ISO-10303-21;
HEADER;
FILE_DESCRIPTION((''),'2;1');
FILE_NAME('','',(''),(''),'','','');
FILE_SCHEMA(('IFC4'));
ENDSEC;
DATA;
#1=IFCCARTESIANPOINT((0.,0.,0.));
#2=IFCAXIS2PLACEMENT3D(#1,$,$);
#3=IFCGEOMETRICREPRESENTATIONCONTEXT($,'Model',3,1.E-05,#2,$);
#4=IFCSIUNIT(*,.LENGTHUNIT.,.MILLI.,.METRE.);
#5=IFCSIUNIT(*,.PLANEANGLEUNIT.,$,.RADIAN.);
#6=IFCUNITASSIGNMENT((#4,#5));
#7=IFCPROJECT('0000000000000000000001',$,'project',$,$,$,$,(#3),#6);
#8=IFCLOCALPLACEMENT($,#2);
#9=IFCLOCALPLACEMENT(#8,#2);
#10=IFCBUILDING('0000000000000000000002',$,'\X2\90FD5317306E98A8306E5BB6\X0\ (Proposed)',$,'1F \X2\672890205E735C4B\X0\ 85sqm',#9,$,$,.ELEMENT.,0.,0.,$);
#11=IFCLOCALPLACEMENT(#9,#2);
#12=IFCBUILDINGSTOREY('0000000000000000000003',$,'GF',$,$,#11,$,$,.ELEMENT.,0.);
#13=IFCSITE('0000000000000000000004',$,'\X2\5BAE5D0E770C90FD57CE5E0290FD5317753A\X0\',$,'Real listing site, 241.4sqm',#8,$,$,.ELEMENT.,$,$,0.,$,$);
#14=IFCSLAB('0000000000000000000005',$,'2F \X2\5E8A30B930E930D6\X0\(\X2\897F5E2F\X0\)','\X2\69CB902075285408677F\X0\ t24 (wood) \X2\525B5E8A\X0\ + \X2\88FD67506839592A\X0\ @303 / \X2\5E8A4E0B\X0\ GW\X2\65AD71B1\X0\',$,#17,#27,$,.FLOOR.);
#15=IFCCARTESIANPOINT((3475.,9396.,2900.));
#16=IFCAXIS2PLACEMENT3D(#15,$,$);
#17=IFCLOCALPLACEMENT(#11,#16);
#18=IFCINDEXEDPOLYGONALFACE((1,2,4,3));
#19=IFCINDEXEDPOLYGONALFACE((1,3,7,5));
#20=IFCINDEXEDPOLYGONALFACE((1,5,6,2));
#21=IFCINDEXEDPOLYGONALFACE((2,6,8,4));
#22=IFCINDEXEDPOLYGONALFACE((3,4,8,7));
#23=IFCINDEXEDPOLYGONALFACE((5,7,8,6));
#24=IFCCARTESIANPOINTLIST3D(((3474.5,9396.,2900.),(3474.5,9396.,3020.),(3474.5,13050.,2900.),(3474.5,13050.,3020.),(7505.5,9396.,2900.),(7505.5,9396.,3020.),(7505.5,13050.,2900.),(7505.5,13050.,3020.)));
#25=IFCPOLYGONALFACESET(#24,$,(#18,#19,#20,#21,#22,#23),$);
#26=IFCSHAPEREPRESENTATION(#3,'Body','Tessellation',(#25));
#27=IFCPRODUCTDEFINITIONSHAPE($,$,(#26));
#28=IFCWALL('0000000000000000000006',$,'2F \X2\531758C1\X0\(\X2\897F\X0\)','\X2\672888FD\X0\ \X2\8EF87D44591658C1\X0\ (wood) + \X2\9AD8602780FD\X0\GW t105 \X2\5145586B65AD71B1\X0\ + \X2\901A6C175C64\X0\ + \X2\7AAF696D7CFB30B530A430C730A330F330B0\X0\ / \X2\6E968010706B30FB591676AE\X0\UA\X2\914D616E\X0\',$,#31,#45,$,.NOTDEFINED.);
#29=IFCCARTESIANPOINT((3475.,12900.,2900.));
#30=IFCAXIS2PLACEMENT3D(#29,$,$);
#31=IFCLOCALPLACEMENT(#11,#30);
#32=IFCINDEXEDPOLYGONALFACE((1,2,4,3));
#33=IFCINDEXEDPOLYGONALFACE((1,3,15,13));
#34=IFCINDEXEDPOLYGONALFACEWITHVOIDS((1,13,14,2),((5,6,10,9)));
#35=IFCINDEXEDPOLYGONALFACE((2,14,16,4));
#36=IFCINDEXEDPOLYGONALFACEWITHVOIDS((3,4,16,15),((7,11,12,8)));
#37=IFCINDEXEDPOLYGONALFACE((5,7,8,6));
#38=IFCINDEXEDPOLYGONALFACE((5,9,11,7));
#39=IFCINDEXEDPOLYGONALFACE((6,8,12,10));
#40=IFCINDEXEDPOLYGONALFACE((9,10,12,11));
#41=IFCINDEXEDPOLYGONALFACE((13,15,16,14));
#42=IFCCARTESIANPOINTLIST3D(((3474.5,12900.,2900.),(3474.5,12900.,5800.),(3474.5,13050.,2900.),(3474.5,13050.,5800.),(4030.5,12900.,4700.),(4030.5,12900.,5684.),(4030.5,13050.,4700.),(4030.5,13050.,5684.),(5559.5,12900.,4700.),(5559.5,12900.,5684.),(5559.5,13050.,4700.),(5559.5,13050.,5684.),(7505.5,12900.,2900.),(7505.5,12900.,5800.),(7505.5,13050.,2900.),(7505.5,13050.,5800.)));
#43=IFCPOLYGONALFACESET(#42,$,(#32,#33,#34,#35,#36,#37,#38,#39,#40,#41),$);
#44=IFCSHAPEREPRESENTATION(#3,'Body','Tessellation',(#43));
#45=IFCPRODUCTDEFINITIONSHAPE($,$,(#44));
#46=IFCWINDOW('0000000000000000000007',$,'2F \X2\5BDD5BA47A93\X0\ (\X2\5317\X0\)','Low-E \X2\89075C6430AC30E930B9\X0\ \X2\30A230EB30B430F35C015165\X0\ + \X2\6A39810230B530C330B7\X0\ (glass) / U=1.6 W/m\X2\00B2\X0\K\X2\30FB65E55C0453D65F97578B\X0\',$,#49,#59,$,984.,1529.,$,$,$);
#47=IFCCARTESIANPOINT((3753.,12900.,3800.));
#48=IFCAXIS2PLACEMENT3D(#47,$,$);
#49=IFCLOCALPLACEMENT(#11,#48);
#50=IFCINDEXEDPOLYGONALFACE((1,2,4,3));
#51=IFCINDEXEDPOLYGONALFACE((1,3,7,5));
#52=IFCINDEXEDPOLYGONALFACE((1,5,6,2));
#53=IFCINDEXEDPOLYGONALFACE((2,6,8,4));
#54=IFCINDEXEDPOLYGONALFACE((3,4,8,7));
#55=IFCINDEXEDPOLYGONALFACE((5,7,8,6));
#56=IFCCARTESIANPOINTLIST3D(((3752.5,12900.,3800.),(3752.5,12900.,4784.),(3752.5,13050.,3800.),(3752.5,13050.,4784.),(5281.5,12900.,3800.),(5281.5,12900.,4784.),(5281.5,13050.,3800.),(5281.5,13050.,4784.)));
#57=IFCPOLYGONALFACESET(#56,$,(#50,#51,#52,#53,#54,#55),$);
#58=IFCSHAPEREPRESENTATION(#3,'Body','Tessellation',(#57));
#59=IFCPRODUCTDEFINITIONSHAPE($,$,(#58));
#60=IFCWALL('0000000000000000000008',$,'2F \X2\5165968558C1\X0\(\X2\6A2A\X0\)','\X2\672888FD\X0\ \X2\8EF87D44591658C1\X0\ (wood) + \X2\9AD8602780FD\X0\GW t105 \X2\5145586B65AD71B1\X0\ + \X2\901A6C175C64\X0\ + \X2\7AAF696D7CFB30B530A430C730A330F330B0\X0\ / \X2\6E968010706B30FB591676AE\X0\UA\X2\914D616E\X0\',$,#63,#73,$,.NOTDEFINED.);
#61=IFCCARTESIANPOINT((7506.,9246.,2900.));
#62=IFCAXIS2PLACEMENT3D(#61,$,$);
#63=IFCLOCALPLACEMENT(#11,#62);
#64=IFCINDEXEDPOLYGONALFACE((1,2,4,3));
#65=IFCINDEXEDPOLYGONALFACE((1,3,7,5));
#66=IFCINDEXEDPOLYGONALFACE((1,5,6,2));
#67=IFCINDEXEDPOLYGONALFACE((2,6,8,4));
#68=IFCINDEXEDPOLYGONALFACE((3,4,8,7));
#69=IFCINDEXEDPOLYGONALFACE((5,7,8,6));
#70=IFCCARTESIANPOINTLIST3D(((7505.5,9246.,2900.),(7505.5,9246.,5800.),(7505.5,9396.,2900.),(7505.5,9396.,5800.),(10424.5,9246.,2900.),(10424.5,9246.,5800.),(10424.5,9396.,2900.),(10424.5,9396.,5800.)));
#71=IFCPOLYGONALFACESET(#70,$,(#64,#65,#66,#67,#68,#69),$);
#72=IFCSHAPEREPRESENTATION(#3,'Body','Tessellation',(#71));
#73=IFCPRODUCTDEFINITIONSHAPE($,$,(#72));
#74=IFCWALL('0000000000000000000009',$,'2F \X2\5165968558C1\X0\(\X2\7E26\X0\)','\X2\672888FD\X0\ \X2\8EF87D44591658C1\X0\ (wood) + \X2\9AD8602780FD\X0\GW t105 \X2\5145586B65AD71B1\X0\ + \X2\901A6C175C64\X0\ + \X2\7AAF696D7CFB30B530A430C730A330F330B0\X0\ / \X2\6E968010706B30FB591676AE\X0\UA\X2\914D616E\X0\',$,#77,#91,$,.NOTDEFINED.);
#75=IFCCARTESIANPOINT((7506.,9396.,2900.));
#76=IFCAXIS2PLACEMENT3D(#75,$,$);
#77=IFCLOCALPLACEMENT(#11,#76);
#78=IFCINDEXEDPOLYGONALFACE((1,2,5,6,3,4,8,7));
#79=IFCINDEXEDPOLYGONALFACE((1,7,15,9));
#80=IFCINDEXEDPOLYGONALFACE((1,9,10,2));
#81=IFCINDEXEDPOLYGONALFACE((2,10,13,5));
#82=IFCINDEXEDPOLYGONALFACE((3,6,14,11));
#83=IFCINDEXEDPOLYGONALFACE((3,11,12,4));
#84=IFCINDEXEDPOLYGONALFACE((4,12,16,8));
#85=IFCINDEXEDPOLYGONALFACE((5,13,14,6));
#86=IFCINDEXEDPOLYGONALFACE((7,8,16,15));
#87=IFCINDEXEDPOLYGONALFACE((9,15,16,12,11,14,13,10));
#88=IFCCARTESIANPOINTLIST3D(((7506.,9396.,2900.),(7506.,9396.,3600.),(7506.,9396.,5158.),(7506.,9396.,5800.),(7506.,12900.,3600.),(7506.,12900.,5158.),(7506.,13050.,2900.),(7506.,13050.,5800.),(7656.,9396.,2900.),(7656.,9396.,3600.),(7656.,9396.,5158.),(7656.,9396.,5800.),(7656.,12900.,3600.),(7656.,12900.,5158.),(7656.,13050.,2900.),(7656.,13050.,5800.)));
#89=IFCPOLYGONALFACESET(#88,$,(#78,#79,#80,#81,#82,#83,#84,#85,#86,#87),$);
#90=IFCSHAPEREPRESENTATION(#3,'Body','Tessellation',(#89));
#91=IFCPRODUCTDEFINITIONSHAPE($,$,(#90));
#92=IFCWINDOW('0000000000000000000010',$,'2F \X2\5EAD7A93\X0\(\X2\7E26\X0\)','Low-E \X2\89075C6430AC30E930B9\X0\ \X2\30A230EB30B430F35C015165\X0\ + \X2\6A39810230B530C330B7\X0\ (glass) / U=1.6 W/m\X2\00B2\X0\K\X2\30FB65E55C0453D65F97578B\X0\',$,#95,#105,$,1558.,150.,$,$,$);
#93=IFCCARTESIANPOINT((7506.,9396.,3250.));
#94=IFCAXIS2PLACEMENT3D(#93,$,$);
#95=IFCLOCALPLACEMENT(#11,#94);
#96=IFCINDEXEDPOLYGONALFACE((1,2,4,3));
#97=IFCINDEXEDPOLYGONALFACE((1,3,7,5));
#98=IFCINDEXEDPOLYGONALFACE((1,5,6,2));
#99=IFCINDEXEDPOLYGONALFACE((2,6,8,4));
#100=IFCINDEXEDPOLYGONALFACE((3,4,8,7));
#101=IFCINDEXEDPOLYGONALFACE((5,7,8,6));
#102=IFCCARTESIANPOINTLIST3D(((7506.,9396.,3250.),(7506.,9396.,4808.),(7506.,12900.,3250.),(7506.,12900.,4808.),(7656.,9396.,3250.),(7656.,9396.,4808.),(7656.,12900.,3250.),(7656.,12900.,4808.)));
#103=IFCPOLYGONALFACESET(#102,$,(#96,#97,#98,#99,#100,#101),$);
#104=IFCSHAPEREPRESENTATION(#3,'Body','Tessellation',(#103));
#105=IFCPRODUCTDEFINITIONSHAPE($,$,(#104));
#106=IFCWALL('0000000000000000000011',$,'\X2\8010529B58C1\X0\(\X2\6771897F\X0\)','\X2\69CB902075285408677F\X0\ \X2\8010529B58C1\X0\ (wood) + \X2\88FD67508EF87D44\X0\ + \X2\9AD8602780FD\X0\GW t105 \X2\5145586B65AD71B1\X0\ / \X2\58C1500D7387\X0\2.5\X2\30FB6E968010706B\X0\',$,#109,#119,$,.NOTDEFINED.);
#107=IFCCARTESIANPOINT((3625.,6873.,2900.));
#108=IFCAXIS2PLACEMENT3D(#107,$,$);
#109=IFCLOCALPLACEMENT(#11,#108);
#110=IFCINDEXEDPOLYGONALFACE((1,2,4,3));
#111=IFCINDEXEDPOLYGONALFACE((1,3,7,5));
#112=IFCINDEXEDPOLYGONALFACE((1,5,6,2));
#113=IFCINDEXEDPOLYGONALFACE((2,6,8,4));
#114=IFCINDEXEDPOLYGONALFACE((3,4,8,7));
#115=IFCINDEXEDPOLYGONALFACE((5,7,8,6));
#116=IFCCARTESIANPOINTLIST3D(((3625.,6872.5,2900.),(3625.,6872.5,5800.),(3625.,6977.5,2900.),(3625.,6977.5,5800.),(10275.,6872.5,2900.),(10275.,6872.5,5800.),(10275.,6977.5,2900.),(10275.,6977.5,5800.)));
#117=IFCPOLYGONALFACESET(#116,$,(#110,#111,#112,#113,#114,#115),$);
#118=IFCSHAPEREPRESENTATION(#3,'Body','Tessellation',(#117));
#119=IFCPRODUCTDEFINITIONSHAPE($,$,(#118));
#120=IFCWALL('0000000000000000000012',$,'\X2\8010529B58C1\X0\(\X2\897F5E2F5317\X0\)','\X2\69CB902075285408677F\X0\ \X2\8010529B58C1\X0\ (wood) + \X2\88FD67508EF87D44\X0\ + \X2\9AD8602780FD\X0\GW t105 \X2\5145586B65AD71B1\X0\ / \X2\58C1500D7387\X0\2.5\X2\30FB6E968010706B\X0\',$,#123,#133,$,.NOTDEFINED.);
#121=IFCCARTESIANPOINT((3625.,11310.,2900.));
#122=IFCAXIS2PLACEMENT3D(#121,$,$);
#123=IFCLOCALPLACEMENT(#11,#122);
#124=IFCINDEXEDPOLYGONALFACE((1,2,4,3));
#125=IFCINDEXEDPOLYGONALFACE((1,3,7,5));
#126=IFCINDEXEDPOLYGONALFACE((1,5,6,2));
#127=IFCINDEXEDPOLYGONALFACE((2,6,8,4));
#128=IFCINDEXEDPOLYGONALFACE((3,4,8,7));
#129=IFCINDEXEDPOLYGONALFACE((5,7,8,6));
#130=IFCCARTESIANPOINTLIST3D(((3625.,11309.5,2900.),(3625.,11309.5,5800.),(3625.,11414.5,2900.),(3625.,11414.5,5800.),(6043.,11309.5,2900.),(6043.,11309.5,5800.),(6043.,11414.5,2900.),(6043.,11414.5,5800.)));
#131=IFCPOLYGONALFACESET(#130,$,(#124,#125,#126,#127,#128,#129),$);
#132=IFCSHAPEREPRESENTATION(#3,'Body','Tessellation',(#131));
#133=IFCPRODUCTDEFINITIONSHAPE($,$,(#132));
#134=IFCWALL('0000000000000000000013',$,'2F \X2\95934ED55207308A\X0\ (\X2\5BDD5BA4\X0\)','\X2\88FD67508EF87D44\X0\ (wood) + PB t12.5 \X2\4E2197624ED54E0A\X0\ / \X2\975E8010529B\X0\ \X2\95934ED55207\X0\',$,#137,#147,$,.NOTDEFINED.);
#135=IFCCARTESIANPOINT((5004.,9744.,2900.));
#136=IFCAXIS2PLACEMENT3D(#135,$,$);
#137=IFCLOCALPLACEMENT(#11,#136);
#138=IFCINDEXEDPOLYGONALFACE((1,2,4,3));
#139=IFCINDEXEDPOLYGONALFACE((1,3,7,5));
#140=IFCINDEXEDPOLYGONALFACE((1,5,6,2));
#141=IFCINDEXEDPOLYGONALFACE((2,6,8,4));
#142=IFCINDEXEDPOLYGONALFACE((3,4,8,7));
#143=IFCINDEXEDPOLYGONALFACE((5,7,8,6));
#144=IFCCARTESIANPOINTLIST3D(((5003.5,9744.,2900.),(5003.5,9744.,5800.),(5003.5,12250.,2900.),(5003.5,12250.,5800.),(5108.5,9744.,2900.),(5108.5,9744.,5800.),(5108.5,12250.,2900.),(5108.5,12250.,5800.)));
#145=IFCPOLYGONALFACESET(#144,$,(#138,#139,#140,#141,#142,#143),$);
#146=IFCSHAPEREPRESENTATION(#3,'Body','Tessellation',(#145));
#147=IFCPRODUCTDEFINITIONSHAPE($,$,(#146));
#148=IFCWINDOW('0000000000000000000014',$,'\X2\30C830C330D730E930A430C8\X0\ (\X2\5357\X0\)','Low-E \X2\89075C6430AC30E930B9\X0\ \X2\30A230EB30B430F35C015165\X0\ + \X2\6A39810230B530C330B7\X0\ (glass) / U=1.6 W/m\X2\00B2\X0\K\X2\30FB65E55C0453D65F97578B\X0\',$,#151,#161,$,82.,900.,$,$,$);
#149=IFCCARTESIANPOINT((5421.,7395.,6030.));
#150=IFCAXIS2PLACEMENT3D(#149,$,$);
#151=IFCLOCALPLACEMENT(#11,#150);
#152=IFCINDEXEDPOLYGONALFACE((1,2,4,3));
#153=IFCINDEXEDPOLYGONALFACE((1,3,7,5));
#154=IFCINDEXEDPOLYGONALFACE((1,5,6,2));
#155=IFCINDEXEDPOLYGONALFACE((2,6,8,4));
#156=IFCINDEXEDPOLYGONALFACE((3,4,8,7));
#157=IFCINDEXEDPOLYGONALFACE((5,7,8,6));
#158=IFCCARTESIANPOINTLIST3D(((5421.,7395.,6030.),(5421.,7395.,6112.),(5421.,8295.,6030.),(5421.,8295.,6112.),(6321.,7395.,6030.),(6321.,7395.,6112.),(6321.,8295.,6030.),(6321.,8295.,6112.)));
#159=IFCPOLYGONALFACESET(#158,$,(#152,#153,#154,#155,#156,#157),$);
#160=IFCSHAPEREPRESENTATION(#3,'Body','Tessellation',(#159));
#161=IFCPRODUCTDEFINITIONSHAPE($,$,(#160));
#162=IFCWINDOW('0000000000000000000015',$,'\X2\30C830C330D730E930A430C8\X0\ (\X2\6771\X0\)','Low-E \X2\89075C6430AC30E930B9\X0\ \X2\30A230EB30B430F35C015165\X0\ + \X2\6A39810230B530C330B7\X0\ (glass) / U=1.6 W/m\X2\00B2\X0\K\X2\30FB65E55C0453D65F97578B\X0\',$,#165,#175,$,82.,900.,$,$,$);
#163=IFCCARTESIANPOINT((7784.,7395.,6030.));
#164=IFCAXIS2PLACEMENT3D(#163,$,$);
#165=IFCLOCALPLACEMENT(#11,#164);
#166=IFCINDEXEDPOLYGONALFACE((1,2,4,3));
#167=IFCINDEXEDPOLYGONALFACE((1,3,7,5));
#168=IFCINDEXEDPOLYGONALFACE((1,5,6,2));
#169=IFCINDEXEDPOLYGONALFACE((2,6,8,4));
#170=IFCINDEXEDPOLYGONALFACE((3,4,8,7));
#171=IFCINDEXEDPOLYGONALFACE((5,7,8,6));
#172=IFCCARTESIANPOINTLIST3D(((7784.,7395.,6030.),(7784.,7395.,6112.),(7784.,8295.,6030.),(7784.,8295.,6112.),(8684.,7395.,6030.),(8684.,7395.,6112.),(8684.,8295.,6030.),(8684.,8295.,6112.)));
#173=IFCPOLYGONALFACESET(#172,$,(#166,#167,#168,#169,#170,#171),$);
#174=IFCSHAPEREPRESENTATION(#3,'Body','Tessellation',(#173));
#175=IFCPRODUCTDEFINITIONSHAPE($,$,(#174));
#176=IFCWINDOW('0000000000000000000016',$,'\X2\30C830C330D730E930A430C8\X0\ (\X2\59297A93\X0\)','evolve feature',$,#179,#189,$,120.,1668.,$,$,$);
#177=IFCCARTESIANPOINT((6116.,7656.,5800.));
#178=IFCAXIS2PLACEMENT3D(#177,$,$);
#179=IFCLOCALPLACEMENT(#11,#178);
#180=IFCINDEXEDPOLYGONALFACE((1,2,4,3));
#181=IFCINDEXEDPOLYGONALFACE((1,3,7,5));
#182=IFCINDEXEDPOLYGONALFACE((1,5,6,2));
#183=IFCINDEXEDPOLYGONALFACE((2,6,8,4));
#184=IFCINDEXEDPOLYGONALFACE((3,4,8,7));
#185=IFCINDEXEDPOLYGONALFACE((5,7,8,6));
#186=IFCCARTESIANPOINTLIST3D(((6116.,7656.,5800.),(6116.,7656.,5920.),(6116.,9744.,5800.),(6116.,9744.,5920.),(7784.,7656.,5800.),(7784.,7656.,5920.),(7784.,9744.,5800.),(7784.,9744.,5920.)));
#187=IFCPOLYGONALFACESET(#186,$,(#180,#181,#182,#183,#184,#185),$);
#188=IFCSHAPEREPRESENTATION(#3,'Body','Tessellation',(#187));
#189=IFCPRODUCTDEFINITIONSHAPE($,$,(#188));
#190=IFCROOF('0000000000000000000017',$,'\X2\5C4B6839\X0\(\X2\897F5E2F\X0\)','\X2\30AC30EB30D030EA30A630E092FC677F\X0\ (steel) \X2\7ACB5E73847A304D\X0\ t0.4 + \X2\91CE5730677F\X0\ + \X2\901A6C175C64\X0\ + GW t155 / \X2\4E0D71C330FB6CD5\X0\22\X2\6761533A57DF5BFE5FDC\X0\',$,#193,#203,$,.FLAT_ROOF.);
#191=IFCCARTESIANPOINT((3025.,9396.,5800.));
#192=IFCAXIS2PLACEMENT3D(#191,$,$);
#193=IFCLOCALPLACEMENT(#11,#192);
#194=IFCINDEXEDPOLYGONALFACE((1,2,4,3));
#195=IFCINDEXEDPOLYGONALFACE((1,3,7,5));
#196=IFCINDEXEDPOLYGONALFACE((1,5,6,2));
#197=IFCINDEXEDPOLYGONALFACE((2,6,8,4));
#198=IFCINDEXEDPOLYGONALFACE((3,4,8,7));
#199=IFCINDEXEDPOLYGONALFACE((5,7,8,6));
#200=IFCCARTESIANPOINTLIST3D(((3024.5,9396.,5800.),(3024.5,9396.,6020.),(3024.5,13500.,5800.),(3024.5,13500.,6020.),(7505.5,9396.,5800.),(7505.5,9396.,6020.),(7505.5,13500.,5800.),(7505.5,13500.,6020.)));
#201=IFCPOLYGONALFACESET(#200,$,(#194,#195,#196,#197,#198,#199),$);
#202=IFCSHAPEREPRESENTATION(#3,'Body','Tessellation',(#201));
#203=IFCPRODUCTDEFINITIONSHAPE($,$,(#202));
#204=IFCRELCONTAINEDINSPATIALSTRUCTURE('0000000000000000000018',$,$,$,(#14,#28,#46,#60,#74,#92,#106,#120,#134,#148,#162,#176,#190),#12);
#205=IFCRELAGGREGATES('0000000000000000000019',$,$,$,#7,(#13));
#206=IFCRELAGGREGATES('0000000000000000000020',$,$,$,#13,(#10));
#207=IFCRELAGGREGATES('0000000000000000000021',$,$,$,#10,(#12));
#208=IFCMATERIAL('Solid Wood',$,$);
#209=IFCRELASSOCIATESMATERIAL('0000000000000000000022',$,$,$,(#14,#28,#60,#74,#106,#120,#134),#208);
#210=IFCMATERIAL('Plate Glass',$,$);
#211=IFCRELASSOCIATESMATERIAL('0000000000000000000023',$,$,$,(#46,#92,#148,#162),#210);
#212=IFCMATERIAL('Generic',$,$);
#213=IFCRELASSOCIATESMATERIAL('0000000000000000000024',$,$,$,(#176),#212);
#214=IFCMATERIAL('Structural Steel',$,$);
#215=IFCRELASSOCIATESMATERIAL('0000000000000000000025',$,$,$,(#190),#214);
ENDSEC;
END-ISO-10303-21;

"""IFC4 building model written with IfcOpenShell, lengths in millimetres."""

from ifc_helpers import new_model, si_unit, frame, frame_2d, origin, place, context, project, spatial, rectangle, extrude, material, element, fill, save


model = new_model("IFC4")

# Units and contexts
model_context = context("Model", 3, precision=1e-05, world=origin())
ifc_project = project(units=[si_unit("LENGTHUNIT", "METRE", prefix="MILLI"), si_unit("PLANEANGLEUNIT", "RADIAN")], contexts=[model_context])

# Site, building, storey
site_placement = place(None, origin())
site = spatial("IfcSite", under=ifc_project, at=site_placement, Name="宮崎県都城市都北町", ObjectType="Real listing site, 241.4sqm", CompositionType="ELEMENT", RefElevation=0.0)
building_placement = place(site_placement, origin())
building = spatial("IfcBuilding", under=site, at=building_placement, Name="都北の風の家 (Proposed)", ObjectType="1F 木造平屋 85sqm", CompositionType="ELEMENT", ElevationOfRefHeight=0.0, ElevationOfTerrain=0.0)
storey_placement = place(building_placement, origin())
storey = spatial("IfcBuildingStorey", under=building, at=storey_placement, Name="GF", CompositionType="ELEMENT", Elevation=0.0)

# Slab
ifc_material_1 = material(Name="Solid Wood")
slab_placement = place(storey_placement, frame((3475.0, 9396.0, 2900.0)))
element("IfcSlab", 1, at=slab_placement, inside=storey, material=ifc_material_1, Name="2F 床スラブ(西帯)", Description="構造用合板 t24 (wood) 剛床 + 製材根太 @303 / 床下 GW断熱", PredefinedType="FLOOR", context=model_context, shape_type="SweptSolid", body=[
    extrude(rectangle(XDim=4031.0, YDim=3654.0, at=frame_2d((2015.0, 1827.0))), frame((3475.0, 9396.0, 2900.0)), (0.0, 0.0, 1.0), 120.0),
])

# Wall, opening, window
wall_1_placement = place(storey_placement, frame((3475.0, 12900.0, 2900.0)))
wall_1 = element("IfcWall", 2, at=wall_1_placement, inside=storey, material=ifc_material_1, Name="2F 北壁(西)", Description="木製 軸組外壁 (wood) + 高性能GW t105 充填断熱 + 通気層 + 窯業系サイディング / 準耐火・外皮UA配慮", PredefinedType="NOTDEFINED", context=model_context, shape_type="SweptSolid", body=[
    extrude(rectangle(XDim=4031.0, YDim=150.0, at=frame_2d((2015.0, 75.0))), frame((3475.0, 12900.0, 2900.0)), (0.0, 0.0, 1.0), 2900.0),
])
opening_1_placement = place(storey_placement, frame((3753.0, 12900.0, 3800.0)))
opening_1 = element("IfcOpeningElement", 3, at=opening_1_placement, cuts=wall_1, PredefinedType="NOTDEFINED", context=model_context, shape_type="SweptSolid", body=[
    extrude(rectangle(XDim=1529.0, YDim=150.0, at=frame_2d((764.0, 75.0))), frame((3753.0, 12900.0, 3800.0)), (0.0, 0.0, 1.0), 984.0),
])
ifc_material_2 = material(Name="Plate Glass")
window_1_placement = place(storey_placement, frame((3753.0, 12900.0, 3800.0)))
window_1 = element("IfcWindow", 4, at=window_1_placement, inside=storey, material=ifc_material_2, Name="2F 寝室窓 (北)", Description="Low-E 複層ガラス アルゴン封入 + 樹脂サッシ (glass) / U=1.6 W/m²K・日射取得型", OverallHeight=984.0, OverallWidth=1529.0, context=model_context, shape_type="SweptSolid", body=[
    extrude(rectangle(XDim=1529.0, YDim=150.0, at=frame_2d((764.0, 75.0))), frame((3753.0, 12900.0, 3800.0)), (0.0, 0.0, 1.0), 984.0),
])
fill(opening_1, window_1)

# Wall
wall_2_placement = place(storey_placement, frame((7506.0, 9246.0, 2900.0)))
element("IfcWall", 5, at=wall_2_placement, inside=storey, material=ifc_material_1, Name="2F 入隅壁(横)", Description="木製 軸組外壁 (wood) + 高性能GW t105 充填断熱 + 通気層 + 窯業系サイディング / 準耐火・外皮UA配慮", PredefinedType="NOTDEFINED", context=model_context, shape_type="SweptSolid", body=[
    extrude(rectangle(XDim=2919.0, YDim=150.0, at=frame_2d((1459.0, 75.0))), frame((7506.0, 9246.0, 2900.0)), (0.0, 0.0, 1.0), 2900.0),
])

# Wall, opening, window
wall_3_placement = place(storey_placement, frame((7506.0, 9396.0, 2900.0)))
wall_3 = element("IfcWall", 6, at=wall_3_placement, inside=storey, material=ifc_material_1, Name="2F 入隅壁(縦)", Description="木製 軸組外壁 (wood) + 高性能GW t105 充填断熱 + 通気層 + 窯業系サイディング / 準耐火・外皮UA配慮", PredefinedType="NOTDEFINED", context=model_context, shape_type="SweptSolid", body=[
    extrude(rectangle(XDim=150.0, YDim=3654.0, at=frame_2d((75.0, 1827.0))), frame((7506.0, 9396.0, 2900.0)), (0.0, 0.0, 1.0), 2900.0),
])
opening_2_placement = place(storey_placement, frame((7506.0, 9396.0, 3250.0)))
opening_2 = element("IfcOpeningElement", 7, at=opening_2_placement, cuts=wall_3, PredefinedType="NOTDEFINED", context=model_context, shape_type="SweptSolid", body=[
    extrude(rectangle(XDim=150.0, YDim=3504.0, at=frame_2d((75.0, 1752.0))), frame((7506.0, 9396.0, 3250.0)), (0.0, 0.0, 1.0), 1558.0),
])
window_2_placement = place(storey_placement, frame((7506.0, 9396.0, 3250.0)))
window_2 = element("IfcWindow", 8, at=window_2_placement, inside=storey, material=ifc_material_2, Name="2F 庭窓(縦)", Description="Low-E 複層ガラス アルゴン封入 + 樹脂サッシ (glass) / U=1.6 W/m²K・日射取得型", OverallHeight=1558.0, OverallWidth=150.0, context=model_context, shape_type="SweptSolid", body=[
    extrude(rectangle(XDim=150.0, YDim=3504.0, at=frame_2d((75.0, 1752.0))), frame((7506.0, 9396.0, 3250.0)), (0.0, 0.0, 1.0), 1558.0),
])
fill(opening_2, window_2)

# Walls
wall_4_placement = place(storey_placement, frame((3625.0, 6873.0, 2900.0)))
element("IfcWall", 9, at=wall_4_placement, inside=storey, material=ifc_material_1, Name="耐力壁(東西)", Description="構造用合板 耐力壁 (wood) + 製材軸組 + 高性能GW t105 充填断熱 / 壁倍率2.5・準耐火", PredefinedType="NOTDEFINED", context=model_context, shape_type="SweptSolid", body=[
    extrude(rectangle(XDim=6650.0, YDim=105.0, at=frame_2d((3325.0, 52.0))), frame((3625.0, 6873.0, 2900.0)), (0.0, 0.0, 1.0), 2900.0),
])
wall_5_placement = place(storey_placement, frame((3625.0, 11310.0, 2900.0)))
element("IfcWall", 10, at=wall_5_placement, inside=storey, material=ifc_material_1, Name="耐力壁(西帯北)", Description="構造用合板 耐力壁 (wood) + 製材軸組 + 高性能GW t105 充填断熱 / 壁倍率2.5・準耐火", PredefinedType="NOTDEFINED", context=model_context, shape_type="SweptSolid", body=[
    extrude(rectangle(XDim=2418.0, YDim=105.0, at=frame_2d((1209.0, 52.0))), frame((3625.0, 11310.0, 2900.0)), (0.0, 0.0, 1.0), 2900.0),
])
wall_6_placement = place(storey_placement, frame((5004.0, 9744.0, 2900.0)))
element("IfcWall", 11, at=wall_6_placement, inside=storey, material=ifc_material_1, Name="2F 間仕切り (寝室)", Description="製材軸組 (wood) + PB t12.5 両面仕上 / 非耐力 間仕切", PredefinedType="NOTDEFINED", context=model_context, shape_type="SweptSolid", body=[
    extrude(rectangle(XDim=105.0, YDim=2506.0, at=frame_2d((52.0, 1253.0))), frame((5004.0, 9744.0, 2900.0)), (0.0, 0.0, 1.0), 2900.0),
])

# Windows
window_3_placement = place(storey_placement, frame((5421.0, 7395.0, 6030.0)))
element("IfcWindow", 12, at=window_3_placement, inside=storey, material=ifc_material_2, Name="トップライト (南)", Description="Low-E 複層ガラス アルゴン封入 + 樹脂サッシ (glass) / U=1.6 W/m²K・日射取得型", OverallHeight=82.0, OverallWidth=900.0, context=model_context, shape_type="SweptSolid", body=[
    extrude(rectangle(XDim=900.0, YDim=900.0, at=frame_2d((450.0, 450.0))), frame((5421.0, 7395.0, 6030.0)), (0.0, 0.0, 1.0), 82.0),
])
window_4_placement = place(storey_placement, frame((7784.0, 7395.0, 6030.0)))
element("IfcWindow", 13, at=window_4_placement, inside=storey, material=ifc_material_2, Name="トップライト (東)", Description="Low-E 複層ガラス アルゴン封入 + 樹脂サッシ (glass) / U=1.6 W/m²K・日射取得型", OverallHeight=82.0, OverallWidth=900.0, context=model_context, shape_type="SweptSolid", body=[
    extrude(rectangle(XDim=900.0, YDim=900.0, at=frame_2d((450.0, 450.0))), frame((7784.0, 7395.0, 6030.0)), (0.0, 0.0, 1.0), 82.0),
])
ifc_material_3 = material(Name="Generic")
window_5_placement = place(storey_placement, frame((6116.0, 7656.0, 5800.0)))
element("IfcWindow", 14, at=window_5_placement, inside=storey, material=ifc_material_3, Name="トップライト (天窓)", Description="evolve feature", OverallHeight=120.0, OverallWidth=1668.0, context=model_context, shape_type="SweptSolid", body=[
    extrude(rectangle(XDim=1668.0, YDim=2088.0, at=frame_2d((834.0, 1044.0))), frame((6116.0, 7656.0, 5800.0)), (0.0, 0.0, 1.0), 120.0),
])

# Roof
ifc_material_4 = material(Name="Structural Steel")
for number, where, name in (
    (15, (3025.0, 9396.0, 5800.0), "屋根(西帯)"),
):
    element("IfcRoof", number, at=place(storey_placement, frame(where)), inside=storey, material=ifc_material_4, Name=name, Description="ガルバリウム鋼板 (steel) 立平葺き t0.4 + 野地板 + 通気層 + GW t155 / 不燃・法22条区域対応", PredefinedType="FLAT_ROOF", context=model_context, shape_type="SweptSolid", body=[
        extrude(rectangle(XDim=4481.0, YDim=4104.0, at=frame_2d((2240.0, 2052.0))), frame((3025.0, 9396.0, 5800.0)), (0.0, 0.0, 1.0), 220.0),
    ])

save(model, "model.ifc")
